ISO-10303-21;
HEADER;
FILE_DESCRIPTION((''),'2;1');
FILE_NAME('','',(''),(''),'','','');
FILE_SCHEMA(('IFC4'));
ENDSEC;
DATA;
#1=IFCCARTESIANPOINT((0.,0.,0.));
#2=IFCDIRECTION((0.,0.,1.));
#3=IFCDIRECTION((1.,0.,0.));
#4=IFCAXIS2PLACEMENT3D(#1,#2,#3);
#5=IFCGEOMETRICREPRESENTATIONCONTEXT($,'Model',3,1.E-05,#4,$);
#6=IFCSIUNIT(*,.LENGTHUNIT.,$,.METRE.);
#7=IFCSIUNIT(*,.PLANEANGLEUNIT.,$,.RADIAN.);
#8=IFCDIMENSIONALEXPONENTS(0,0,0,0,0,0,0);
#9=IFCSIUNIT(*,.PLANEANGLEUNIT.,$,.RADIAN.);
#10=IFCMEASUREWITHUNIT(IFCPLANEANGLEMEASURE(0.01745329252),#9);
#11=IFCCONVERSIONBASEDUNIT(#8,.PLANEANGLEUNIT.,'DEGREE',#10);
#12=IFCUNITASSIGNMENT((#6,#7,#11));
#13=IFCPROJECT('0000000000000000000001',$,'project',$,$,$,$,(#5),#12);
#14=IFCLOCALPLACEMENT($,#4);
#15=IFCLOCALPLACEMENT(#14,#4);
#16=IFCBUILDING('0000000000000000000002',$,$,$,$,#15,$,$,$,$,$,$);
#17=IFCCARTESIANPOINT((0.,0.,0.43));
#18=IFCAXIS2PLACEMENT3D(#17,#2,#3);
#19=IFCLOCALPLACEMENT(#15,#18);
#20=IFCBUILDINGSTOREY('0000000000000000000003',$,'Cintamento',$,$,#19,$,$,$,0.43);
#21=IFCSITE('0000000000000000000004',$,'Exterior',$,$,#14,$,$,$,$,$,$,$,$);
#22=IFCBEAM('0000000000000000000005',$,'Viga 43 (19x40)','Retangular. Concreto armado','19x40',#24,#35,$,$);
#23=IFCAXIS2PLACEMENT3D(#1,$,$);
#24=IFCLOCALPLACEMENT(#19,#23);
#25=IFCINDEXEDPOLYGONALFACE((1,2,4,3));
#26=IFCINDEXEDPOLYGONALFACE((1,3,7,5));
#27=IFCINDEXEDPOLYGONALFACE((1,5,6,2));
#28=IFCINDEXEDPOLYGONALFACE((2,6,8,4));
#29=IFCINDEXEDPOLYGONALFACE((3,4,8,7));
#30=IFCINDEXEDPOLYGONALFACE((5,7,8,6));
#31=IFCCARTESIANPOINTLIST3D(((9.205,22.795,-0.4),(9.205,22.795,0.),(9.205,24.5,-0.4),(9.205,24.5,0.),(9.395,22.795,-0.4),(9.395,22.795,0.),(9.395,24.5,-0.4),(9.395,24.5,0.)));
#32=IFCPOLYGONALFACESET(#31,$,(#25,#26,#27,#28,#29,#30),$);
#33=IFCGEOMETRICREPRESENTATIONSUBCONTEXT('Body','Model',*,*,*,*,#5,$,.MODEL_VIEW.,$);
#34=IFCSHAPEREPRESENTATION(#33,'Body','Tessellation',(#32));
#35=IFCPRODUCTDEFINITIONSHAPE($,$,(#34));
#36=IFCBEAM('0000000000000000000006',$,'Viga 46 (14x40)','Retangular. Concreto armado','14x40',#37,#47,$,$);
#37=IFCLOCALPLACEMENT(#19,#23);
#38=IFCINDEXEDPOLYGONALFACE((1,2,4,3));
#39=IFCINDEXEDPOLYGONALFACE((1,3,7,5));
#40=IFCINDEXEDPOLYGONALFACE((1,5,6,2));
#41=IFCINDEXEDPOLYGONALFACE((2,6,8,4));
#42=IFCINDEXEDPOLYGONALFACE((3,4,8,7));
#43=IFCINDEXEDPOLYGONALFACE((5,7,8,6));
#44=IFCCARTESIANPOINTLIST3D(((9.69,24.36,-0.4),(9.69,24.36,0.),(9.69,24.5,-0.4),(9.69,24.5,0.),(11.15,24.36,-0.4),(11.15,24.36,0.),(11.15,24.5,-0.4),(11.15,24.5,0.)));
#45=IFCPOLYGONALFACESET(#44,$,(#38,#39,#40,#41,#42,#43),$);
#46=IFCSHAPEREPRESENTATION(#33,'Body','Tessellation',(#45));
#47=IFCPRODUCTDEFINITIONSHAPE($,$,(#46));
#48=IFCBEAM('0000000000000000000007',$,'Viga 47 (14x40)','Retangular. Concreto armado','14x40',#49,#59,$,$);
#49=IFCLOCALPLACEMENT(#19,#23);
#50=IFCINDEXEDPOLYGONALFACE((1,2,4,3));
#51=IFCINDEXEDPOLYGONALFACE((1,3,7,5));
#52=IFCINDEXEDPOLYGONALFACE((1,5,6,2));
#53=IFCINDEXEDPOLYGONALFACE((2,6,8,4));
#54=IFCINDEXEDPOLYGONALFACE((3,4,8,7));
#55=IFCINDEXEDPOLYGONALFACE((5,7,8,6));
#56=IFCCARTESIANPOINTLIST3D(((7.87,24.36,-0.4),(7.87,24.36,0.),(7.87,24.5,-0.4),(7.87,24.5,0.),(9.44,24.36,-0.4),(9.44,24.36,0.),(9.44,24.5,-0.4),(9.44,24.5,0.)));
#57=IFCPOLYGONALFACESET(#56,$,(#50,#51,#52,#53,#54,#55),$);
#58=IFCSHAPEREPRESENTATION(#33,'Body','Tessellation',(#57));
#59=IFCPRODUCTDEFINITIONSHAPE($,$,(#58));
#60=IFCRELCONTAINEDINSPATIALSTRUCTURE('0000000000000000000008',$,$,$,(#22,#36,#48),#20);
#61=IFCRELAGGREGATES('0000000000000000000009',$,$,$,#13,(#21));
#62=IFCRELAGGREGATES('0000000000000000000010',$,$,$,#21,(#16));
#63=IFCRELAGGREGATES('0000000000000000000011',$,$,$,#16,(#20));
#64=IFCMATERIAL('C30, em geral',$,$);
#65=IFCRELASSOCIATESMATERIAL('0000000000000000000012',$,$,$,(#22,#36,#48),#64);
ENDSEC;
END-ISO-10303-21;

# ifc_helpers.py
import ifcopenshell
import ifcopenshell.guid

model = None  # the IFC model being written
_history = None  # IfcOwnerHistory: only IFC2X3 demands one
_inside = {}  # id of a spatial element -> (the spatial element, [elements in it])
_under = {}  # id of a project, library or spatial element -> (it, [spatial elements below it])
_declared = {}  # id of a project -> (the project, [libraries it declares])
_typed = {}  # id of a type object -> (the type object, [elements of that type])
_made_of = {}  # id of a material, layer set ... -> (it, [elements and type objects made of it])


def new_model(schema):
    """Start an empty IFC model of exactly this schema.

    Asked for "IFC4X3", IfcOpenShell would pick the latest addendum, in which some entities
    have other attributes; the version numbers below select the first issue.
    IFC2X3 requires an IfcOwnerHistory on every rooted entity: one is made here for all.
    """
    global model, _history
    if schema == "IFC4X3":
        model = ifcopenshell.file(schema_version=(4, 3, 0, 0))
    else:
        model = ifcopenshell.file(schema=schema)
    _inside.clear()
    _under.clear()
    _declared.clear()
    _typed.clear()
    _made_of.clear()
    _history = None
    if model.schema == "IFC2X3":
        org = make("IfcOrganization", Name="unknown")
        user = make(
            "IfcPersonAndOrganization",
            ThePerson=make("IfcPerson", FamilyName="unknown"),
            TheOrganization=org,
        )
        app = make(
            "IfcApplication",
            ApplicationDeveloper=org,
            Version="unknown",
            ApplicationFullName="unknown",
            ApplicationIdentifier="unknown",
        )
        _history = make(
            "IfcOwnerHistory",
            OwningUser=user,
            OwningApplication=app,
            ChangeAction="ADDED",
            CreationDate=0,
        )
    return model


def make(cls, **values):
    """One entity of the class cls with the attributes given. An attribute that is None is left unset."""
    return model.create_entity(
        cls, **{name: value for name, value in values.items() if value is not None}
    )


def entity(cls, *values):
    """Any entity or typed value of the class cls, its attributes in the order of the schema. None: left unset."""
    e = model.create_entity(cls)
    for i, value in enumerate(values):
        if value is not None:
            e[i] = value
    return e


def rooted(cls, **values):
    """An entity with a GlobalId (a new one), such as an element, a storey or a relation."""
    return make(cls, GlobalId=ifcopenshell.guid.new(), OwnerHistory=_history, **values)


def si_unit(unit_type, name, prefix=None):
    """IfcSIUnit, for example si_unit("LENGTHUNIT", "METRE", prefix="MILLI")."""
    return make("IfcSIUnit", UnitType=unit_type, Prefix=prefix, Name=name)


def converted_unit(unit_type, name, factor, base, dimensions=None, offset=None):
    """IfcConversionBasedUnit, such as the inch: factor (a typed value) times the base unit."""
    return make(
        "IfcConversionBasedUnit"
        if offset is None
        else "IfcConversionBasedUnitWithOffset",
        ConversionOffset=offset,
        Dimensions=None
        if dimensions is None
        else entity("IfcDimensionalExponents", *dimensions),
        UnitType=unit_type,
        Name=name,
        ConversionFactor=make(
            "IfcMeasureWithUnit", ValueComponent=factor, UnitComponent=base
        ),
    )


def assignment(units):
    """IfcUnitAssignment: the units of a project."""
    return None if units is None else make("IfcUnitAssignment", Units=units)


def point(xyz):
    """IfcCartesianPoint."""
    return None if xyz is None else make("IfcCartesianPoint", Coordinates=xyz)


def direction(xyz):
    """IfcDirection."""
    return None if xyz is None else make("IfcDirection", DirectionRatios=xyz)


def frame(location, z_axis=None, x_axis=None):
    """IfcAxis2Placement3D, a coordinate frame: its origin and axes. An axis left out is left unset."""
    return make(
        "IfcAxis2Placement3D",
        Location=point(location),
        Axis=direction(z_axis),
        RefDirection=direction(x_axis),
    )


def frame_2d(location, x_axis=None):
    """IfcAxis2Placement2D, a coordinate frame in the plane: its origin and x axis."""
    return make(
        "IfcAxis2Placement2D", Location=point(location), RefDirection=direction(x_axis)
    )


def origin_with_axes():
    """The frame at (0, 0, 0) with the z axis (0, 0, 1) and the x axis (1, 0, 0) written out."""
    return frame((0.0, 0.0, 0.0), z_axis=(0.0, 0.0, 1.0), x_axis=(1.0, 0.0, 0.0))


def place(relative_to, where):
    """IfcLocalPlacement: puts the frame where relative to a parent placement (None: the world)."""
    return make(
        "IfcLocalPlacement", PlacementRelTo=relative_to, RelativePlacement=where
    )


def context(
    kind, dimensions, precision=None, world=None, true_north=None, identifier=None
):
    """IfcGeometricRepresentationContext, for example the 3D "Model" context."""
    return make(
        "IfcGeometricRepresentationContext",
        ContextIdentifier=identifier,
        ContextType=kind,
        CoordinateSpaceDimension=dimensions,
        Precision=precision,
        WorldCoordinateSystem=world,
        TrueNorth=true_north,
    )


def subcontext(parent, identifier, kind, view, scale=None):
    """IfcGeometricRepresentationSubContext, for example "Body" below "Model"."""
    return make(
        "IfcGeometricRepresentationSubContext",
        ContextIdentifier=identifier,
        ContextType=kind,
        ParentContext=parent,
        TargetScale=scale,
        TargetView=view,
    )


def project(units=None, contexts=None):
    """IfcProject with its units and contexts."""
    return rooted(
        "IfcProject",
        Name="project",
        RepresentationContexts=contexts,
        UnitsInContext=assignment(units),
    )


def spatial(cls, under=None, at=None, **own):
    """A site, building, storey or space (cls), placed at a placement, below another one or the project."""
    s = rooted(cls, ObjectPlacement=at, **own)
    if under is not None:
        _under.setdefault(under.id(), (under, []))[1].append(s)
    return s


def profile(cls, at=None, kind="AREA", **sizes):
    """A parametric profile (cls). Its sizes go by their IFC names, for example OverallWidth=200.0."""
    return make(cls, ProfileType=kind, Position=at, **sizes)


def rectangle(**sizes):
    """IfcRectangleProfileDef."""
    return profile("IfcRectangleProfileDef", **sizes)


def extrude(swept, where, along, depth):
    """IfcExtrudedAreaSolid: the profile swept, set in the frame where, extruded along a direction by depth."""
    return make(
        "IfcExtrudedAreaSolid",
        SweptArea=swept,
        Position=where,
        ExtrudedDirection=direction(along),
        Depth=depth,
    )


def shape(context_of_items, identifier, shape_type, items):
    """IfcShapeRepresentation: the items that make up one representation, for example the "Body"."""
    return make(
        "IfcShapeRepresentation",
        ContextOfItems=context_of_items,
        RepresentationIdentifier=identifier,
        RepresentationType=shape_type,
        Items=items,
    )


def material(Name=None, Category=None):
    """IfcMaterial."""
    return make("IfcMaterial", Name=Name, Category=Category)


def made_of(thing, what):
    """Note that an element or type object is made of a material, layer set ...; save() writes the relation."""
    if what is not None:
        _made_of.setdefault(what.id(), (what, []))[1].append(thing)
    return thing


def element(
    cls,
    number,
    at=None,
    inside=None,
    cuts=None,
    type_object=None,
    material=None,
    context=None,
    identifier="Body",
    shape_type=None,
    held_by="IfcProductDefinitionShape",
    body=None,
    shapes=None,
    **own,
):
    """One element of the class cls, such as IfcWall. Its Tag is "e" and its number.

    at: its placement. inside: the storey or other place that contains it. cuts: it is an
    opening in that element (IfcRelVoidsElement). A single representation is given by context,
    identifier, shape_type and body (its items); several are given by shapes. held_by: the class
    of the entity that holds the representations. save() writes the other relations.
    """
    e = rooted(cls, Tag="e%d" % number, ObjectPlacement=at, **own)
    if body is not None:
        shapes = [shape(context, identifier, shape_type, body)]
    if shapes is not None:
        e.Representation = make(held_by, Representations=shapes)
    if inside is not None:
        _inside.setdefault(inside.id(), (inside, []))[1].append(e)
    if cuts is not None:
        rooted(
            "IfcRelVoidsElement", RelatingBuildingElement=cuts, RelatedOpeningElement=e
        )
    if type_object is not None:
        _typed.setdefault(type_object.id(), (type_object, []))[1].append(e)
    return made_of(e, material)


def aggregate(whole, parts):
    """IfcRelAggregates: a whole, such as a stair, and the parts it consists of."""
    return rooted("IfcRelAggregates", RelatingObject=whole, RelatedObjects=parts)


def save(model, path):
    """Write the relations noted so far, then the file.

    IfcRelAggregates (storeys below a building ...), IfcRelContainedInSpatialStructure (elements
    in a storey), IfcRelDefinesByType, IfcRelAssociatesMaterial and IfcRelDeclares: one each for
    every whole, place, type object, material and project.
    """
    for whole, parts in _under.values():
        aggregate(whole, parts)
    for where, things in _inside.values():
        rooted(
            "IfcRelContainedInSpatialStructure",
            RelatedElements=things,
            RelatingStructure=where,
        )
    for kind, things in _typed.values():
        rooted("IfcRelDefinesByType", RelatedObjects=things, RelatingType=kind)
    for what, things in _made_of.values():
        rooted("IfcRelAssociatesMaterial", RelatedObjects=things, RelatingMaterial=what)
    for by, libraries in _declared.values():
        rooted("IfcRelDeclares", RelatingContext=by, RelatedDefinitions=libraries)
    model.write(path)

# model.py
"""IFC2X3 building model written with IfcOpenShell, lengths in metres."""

from ifc_helpers import new_model, entity, si_unit, converted_unit, frame, frame_2d, origin_with_axes, place, context, subcontext, project, spatial, rectangle, extrude, material, element, save


model = new_model("IFC2X3")

# Units and contexts
model_context = context("Model", 3, precision=1e-05, world=origin_with_axes())
body_context = subcontext(model_context, "Body", "Model", "MODEL_VIEW")
ifc_project = project(units=[si_unit("LENGTHUNIT", "METRE"), si_unit("PLANEANGLEUNIT", "RADIAN"), converted_unit("PLANEANGLEUNIT", "DEGREE", entity("IfcPlaneAngleMeasure", 0.01745329252), si_unit("PLANEANGLEUNIT", "RADIAN"), dimensions=[0, 0, 0, 0, 0, 0, 0])], contexts=[model_context])

# Site, building, storey
site_placement = place(None, origin_with_axes())
site = spatial("IfcSite", under=ifc_project, at=site_placement, Name="Exterior")
building_placement = place(site_placement, origin_with_axes())
building = spatial("IfcBuilding", under=site, at=building_placement)
storey_placement = place(building_placement, frame((0.0, 0.0, 0.43), z_axis=(0.0, 0.0, 1.0), x_axis=(1.0, 0.0, 0.0)))
storey = spatial("IfcBuildingStorey", under=building, at=storey_placement, Name="Cintamento", Elevation=0.43)

# Beams
ifc_material_1 = material(Name="C30, em geral")
beam_1_placement = place(storey_placement, frame((9.3, 22.795, 0.0), z_axis=(0.0, 1.0, 0.0), x_axis=(-1.0, 0.0, 0.0)))
element("IfcBeam", 1, at=beam_1_placement, inside=storey, material=ifc_material_1, Name="Viga 43 (19x40)", Description="Retangular. Concreto armado", ObjectType="19x40", context=body_context, shape_type="SweptSolid", body=[
    extrude(rectangle(XDim=0.19, YDim=0.4, at=frame_2d((0.0, -0.2), x_axis=(1.0, 0.0))), origin_with_axes(), (0.0, 0.0, 1.0), 1.705),
])
beam_2_placement = place(storey_placement, frame((9.69, 24.43, 0.0), z_axis=(1.0, 0.0, 0.0), x_axis=(0.0, 1.0, 0.0)))
element("IfcBeam", 2, at=beam_2_placement, inside=storey, material=ifc_material_1, Name="Viga 46 (14x40)", Description="Retangular. Concreto armado", ObjectType="14x40", context=body_context, shape_type="SweptSolid", body=[
    extrude(rectangle(XDim=0.14, YDim=0.4, at=frame_2d((0.0, -0.2), x_axis=(1.0, 0.0))), origin_with_axes(), (0.0, 0.0, 1.0), 1.46),
])
beam_3_placement = place(storey_placement, frame((7.87, 24.43, 0.0), z_axis=(1.0, 0.0, 0.0), x_axis=(0.0, 1.0, 0.0)))
element("IfcBeam", 3, at=beam_3_placement, inside=storey, material=ifc_material_1, Name="Viga 47 (14x40)", Description="Retangular. Concreto armado", ObjectType="14x40", context=body_context, shape_type="SweptSolid", body=[
    extrude(rectangle(XDim=0.14, YDim=0.4, at=frame_2d((0.0, -0.2), x_axis=(1.0, 0.0))), origin_with_axes(), (0.0, 0.0, 1.0), 1.57),
])

save(model, "model.ifc")
